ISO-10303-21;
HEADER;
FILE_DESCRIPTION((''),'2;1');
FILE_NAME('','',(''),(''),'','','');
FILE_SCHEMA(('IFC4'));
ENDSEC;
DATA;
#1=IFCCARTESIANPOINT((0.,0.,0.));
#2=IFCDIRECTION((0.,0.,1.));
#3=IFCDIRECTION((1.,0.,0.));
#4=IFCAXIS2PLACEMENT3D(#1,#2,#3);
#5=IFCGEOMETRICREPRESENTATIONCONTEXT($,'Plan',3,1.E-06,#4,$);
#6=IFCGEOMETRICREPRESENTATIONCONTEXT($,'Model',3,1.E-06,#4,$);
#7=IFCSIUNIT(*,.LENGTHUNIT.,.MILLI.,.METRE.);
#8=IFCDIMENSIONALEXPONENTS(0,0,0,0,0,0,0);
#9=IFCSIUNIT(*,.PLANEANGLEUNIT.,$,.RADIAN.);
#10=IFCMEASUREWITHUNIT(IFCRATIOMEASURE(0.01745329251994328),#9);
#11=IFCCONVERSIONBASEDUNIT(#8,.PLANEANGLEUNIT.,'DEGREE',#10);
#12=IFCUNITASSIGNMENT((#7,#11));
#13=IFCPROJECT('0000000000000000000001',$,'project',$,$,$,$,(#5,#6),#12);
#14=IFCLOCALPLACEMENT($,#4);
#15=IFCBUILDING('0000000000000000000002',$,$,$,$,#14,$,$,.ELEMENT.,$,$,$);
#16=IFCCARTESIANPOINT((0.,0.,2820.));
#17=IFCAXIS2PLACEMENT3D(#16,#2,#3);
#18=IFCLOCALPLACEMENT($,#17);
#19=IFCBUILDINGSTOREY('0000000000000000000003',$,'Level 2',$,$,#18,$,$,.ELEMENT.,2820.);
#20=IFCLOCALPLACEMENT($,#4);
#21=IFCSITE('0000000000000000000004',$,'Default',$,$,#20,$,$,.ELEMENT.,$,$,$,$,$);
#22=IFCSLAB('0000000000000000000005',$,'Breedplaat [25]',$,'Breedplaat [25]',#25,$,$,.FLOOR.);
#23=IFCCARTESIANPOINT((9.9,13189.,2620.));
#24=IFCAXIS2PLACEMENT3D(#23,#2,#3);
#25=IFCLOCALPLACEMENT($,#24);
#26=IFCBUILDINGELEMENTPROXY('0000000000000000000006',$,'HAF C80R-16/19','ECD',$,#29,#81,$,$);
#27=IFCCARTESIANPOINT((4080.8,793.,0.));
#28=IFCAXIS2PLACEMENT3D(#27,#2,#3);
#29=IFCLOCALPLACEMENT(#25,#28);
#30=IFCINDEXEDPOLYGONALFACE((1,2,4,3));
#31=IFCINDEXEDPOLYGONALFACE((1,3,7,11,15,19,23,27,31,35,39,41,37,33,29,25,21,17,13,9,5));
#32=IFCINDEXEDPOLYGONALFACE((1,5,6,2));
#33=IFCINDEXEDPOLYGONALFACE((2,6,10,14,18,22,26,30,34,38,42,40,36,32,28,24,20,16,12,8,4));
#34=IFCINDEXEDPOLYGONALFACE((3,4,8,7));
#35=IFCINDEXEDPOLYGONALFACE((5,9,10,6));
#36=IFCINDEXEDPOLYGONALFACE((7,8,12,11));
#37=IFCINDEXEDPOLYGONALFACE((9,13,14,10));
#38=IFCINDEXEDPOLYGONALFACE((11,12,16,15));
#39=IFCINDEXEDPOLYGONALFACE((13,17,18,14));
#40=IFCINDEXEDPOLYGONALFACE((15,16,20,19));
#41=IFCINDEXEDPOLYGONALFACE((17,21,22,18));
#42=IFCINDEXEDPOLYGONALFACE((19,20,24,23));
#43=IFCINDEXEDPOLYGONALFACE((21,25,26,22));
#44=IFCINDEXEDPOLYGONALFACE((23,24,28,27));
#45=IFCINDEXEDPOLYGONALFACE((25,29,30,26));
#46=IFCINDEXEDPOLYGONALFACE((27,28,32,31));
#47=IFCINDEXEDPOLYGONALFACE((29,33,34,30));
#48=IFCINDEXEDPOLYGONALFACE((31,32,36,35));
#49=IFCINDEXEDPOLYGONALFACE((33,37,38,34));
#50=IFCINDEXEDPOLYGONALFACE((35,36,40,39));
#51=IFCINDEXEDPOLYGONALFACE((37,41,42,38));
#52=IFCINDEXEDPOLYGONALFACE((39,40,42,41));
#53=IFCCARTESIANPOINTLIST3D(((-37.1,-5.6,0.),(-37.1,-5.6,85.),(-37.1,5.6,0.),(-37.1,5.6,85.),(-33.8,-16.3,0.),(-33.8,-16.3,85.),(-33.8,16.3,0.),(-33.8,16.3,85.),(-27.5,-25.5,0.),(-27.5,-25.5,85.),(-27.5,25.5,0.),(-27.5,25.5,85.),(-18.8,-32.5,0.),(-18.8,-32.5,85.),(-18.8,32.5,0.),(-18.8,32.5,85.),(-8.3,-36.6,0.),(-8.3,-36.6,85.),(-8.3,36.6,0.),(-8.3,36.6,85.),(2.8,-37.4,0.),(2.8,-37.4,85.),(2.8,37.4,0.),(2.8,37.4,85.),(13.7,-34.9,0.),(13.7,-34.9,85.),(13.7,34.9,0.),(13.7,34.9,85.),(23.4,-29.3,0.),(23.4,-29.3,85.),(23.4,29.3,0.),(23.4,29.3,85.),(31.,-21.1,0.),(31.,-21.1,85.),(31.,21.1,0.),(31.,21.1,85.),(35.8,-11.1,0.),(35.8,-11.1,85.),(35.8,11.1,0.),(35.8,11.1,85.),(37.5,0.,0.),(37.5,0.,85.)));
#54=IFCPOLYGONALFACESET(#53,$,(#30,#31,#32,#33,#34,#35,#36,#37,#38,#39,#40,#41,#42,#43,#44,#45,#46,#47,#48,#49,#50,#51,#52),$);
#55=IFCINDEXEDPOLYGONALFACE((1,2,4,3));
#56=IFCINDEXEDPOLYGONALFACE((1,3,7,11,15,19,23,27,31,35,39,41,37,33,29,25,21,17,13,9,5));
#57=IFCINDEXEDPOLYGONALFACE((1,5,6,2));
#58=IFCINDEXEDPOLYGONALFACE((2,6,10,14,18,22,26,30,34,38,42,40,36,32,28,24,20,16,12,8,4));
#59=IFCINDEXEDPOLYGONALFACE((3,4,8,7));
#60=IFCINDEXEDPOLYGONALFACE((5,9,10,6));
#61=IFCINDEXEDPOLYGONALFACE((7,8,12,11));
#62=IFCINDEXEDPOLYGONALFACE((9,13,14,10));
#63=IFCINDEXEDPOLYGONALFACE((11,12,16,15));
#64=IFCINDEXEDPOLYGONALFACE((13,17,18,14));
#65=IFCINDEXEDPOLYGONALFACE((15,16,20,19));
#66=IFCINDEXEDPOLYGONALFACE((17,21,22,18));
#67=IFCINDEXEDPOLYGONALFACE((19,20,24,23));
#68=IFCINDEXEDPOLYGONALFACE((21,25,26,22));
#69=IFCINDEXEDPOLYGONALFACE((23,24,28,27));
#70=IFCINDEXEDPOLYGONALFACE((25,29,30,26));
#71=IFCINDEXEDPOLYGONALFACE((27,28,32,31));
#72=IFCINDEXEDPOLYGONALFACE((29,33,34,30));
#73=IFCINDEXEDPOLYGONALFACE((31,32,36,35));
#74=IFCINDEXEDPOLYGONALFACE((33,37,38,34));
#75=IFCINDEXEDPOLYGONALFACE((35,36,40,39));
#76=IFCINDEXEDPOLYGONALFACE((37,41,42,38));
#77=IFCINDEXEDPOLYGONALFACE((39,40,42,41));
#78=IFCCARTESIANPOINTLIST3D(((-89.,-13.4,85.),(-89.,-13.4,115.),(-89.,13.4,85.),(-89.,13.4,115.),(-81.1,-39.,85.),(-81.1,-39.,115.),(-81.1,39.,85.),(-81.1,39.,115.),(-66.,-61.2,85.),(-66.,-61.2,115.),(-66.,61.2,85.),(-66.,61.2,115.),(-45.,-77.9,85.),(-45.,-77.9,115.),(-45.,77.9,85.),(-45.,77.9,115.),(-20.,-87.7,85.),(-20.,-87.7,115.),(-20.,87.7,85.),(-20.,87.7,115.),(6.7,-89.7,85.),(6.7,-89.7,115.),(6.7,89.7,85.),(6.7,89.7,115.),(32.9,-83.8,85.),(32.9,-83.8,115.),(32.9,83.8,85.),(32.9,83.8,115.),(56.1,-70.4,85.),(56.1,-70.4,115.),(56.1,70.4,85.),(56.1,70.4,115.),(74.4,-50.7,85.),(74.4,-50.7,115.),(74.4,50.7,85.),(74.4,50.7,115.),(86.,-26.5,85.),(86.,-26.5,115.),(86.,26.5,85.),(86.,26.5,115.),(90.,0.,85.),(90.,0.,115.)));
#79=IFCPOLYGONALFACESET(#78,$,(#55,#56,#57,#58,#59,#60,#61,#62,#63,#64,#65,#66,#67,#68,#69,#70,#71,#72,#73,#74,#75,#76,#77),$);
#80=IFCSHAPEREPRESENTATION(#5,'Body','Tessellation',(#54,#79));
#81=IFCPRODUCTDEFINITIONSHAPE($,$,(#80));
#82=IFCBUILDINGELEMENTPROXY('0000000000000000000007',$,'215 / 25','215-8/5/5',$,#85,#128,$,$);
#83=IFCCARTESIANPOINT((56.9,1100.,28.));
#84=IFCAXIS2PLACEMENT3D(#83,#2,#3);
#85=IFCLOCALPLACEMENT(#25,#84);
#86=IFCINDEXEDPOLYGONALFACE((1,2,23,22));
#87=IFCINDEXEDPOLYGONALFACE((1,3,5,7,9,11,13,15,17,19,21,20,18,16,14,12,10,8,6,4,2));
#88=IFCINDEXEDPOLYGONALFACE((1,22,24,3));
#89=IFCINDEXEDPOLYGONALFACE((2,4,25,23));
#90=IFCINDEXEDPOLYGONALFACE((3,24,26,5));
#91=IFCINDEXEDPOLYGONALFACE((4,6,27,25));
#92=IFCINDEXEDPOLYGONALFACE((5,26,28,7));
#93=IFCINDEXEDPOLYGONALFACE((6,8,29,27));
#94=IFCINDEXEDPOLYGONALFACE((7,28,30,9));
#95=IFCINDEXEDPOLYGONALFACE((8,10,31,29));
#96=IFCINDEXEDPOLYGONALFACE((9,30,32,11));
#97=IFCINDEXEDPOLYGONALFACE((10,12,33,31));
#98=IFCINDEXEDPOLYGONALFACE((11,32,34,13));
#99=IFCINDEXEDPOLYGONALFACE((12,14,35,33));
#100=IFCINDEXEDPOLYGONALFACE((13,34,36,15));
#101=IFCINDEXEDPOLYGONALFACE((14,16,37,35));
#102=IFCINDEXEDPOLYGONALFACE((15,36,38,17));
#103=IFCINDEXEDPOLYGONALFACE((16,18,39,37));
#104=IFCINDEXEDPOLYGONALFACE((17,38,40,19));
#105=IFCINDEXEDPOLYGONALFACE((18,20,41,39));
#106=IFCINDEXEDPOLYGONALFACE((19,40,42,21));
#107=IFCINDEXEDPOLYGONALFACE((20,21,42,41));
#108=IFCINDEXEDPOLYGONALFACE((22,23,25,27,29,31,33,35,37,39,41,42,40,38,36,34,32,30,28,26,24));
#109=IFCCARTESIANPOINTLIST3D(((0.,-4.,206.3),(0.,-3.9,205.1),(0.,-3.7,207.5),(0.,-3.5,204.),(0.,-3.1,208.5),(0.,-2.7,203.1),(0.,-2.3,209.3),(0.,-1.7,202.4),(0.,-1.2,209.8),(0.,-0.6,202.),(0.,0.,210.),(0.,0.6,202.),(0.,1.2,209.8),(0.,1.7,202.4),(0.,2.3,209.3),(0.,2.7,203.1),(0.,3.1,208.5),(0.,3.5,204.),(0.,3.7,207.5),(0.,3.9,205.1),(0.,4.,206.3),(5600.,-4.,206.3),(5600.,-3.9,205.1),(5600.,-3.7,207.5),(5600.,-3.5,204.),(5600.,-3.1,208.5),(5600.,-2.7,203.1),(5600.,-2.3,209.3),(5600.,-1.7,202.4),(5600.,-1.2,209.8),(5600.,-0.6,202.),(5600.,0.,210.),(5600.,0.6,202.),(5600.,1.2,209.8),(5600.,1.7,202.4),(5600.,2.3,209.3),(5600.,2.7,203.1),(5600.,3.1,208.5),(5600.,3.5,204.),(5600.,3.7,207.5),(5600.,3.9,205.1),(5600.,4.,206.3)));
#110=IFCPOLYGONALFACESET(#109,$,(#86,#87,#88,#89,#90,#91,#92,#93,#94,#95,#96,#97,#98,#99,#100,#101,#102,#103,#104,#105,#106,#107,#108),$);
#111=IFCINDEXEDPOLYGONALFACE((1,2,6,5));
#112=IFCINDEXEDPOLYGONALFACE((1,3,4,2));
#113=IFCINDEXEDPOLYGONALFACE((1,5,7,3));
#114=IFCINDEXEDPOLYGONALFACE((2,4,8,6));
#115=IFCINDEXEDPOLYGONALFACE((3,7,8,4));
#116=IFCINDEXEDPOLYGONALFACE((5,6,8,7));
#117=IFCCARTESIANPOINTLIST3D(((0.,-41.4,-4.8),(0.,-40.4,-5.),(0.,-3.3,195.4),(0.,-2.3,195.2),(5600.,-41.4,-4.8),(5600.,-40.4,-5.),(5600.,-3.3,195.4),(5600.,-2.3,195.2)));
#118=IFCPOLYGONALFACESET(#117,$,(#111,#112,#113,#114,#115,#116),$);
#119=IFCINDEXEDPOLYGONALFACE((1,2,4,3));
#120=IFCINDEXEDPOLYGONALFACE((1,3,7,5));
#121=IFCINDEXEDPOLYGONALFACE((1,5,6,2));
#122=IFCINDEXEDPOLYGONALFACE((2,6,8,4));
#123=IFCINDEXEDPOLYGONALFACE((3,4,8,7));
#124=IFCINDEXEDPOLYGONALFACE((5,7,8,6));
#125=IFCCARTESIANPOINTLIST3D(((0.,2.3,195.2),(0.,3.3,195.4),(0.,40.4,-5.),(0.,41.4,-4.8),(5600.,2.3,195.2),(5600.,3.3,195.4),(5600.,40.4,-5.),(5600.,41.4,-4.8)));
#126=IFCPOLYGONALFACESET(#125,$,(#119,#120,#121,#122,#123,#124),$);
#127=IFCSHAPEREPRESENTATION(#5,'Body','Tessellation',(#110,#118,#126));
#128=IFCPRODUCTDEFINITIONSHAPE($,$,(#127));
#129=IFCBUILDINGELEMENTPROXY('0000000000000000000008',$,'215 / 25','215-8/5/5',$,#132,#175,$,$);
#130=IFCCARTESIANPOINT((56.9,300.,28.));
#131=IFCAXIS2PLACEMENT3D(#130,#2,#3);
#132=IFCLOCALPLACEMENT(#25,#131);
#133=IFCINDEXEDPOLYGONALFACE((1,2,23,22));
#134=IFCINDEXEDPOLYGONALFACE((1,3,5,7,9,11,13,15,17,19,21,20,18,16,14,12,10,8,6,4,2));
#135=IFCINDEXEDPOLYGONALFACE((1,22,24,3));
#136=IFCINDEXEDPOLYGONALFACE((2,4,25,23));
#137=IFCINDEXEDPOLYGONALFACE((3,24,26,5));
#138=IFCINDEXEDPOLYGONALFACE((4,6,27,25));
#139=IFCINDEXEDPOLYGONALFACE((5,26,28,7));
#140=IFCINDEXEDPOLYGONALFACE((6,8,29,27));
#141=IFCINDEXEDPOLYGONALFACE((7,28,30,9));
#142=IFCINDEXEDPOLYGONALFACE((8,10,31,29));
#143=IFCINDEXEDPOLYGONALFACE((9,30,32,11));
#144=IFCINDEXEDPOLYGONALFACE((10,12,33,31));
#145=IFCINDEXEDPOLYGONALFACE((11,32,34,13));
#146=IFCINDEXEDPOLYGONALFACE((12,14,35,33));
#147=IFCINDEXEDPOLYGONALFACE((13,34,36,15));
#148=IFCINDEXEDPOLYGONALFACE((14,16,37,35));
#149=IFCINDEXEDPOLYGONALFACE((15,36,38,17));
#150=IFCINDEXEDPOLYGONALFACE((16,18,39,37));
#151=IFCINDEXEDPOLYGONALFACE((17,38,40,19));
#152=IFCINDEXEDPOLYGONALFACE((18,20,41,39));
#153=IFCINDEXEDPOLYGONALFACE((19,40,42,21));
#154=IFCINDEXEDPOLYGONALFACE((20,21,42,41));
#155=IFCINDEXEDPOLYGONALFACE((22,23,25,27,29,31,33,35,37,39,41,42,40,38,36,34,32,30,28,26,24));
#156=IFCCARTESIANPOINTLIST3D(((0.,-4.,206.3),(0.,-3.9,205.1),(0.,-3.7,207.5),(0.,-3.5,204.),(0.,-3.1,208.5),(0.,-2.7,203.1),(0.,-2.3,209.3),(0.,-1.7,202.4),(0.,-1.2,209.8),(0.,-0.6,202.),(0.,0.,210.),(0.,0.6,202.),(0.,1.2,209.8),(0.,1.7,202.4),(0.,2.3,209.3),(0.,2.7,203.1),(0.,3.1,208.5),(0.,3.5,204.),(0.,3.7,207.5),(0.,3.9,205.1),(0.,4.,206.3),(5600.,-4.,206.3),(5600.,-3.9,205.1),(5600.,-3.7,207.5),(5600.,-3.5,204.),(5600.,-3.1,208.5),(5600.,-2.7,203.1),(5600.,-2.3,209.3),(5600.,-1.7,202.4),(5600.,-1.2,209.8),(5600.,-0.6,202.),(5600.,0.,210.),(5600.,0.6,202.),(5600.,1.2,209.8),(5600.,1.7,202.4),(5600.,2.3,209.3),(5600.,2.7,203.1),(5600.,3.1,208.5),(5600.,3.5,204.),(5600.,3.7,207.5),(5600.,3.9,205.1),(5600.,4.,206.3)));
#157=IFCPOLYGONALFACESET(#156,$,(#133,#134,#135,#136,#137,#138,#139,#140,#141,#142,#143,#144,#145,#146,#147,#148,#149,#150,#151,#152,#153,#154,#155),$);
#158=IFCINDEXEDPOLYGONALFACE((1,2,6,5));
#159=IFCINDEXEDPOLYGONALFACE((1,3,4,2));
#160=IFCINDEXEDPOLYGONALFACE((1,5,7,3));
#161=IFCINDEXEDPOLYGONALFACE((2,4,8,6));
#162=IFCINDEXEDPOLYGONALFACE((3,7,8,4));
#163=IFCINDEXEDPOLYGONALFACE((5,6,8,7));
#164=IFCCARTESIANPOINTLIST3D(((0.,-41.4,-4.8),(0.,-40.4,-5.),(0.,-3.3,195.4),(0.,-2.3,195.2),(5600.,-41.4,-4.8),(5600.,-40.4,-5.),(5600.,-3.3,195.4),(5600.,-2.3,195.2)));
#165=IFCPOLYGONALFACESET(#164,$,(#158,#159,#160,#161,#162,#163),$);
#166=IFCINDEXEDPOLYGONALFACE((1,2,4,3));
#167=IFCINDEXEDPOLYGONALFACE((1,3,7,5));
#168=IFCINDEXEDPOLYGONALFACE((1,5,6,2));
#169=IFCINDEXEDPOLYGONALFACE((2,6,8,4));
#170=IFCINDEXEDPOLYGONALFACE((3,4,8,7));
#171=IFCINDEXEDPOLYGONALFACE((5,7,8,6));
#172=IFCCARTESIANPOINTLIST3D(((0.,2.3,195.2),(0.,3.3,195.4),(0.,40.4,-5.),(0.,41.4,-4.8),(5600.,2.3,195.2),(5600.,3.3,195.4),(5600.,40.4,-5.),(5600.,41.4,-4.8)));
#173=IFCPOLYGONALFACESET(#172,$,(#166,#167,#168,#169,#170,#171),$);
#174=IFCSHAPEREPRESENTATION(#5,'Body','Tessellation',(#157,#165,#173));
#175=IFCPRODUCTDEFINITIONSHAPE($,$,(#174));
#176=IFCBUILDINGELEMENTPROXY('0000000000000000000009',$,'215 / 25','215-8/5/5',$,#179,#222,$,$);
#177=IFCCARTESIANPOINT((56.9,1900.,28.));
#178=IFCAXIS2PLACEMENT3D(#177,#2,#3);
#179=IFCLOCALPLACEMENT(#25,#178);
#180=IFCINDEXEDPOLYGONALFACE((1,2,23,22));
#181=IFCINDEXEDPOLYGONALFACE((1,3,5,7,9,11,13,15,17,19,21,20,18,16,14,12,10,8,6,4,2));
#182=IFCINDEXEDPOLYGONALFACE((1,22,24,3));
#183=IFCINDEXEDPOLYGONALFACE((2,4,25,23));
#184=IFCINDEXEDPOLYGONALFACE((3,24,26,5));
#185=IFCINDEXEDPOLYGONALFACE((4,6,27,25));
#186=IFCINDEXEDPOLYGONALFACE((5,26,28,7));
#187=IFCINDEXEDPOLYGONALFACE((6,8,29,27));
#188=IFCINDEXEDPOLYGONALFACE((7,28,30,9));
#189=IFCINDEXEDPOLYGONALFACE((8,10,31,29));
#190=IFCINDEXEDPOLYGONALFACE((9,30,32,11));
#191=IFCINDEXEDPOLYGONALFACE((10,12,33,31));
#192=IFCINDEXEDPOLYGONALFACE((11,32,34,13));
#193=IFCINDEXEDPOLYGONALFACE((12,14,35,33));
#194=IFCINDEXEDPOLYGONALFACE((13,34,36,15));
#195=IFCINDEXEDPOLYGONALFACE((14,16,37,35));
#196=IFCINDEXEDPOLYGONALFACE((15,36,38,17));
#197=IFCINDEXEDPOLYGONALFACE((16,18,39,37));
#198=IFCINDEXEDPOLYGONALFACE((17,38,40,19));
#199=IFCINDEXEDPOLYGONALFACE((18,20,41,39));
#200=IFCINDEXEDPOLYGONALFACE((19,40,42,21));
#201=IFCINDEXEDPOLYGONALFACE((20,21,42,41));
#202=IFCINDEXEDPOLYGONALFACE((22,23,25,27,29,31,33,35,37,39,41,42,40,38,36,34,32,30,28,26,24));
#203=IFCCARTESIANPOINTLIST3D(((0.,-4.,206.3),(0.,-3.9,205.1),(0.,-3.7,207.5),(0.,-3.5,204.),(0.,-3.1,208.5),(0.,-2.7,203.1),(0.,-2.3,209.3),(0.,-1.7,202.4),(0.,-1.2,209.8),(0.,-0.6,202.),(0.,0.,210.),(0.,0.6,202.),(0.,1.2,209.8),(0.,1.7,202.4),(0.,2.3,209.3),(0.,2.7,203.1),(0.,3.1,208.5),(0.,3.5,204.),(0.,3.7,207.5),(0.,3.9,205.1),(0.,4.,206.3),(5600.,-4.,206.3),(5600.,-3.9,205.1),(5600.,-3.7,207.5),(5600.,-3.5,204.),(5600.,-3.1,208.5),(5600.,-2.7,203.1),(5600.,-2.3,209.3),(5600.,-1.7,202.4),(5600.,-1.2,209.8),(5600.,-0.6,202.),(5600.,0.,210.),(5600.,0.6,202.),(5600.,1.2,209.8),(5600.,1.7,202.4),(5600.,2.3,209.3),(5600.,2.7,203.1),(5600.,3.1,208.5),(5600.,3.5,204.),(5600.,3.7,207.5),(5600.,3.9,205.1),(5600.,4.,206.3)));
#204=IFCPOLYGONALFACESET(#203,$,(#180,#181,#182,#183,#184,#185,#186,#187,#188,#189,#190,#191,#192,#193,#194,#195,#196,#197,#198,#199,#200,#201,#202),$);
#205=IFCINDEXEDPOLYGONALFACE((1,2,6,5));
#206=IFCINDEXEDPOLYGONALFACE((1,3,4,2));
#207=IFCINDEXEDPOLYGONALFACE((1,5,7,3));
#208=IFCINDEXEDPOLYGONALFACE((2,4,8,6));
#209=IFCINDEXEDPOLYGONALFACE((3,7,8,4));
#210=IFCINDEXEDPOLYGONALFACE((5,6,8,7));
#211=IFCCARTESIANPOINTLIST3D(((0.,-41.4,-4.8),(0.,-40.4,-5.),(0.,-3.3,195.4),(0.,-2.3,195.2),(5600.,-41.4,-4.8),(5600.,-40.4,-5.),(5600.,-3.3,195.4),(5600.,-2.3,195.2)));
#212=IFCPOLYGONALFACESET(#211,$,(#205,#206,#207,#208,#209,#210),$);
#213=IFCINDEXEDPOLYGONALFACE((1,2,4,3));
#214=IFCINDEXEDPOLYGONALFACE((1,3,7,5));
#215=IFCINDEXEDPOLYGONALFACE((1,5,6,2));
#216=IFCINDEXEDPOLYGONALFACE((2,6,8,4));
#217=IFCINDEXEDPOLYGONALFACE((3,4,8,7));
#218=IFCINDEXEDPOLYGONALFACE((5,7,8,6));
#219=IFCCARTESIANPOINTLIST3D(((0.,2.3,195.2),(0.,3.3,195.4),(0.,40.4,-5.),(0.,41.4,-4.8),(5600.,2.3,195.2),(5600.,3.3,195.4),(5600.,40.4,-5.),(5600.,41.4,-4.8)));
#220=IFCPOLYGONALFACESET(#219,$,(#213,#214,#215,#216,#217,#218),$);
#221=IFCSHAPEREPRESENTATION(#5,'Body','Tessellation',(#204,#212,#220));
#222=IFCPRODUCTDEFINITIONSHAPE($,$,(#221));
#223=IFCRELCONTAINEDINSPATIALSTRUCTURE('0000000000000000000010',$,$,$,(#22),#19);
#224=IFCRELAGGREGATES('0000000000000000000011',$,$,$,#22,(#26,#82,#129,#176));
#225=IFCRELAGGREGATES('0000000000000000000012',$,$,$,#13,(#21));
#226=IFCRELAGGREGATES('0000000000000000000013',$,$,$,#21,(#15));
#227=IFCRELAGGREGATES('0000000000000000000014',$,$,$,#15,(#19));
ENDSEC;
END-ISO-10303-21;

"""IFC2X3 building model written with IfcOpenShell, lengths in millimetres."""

from ifc_helpers import new_model, entity, si_unit, converted_unit, frame, origin_with_axes, origin_2d_with_axis, place, context, project, spatial, rectangle, circle, extrude, element, aggregate, save


model = new_model("IFC2X3")

# Units and contexts
plan_context = context("Plan", 3, precision=1e-06, world=origin_with_axes())
model_context = context("Model", 3, precision=1e-06, world=origin_with_axes())
ifc_project = project(units=[si_unit("LENGTHUNIT", "METRE", prefix="MILLI"), converted_unit("PLANEANGLEUNIT", "DEGREE", entity("IfcRatioMeasure", 0.01745329251994328), si_unit("PLANEANGLEUNIT", "RADIAN"), dimensions=[0, 0, 0, 0, 0, 0, 0])], contexts=[plan_context, model_context])

# Site, building, storey
site_placement = place(None, origin_with_axes())
site = spatial("IfcSite", under=ifc_project, at=site_placement, Name="Default", CompositionType="ELEMENT")
building_placement = place(None, origin_with_axes())
building = spatial("IfcBuilding", under=site, at=building_placement, CompositionType="ELEMENT")
storey_placement = place(None, frame((0.0, 0.0, 2820.0), z_axis=(0.0, 0.0, 1.0), x_axis=(1.0, 0.0, 0.0)))
storey = spatial("IfcBuildingStorey", under=building, at=storey_placement, Name="Level 2", CompositionType="ELEMENT", Elevation=2820.0)

# Slab, building element proxies
slab_1_placement = place(None, frame((9.9, 13189.0, 2620.0), z_axis=(0.0, 0.0, 1.0), x_axis=(1.0, 0.0, 0.0)))
slab_1 = element("IfcSlab", 1, at=slab_1_placement, inside=storey, Name="Breedplaat [25]", ObjectType="Breedplaat [25]", PredefinedType="FLOOR")
proxy_1_placement = place(slab_1_placement, frame((4080.8, 793.0, 0.0), z_axis=(0.0, 0.0, 1.0), x_axis=(1.0, 0.0, 0.0)))
proxy_1 = element("IfcBuildingElementProxy", 2, at=proxy_1_placement, Name="HAF C80R-16/19", Description="ECD", context=plan_context, shape_type="SweptSolid", body=[
    extrude(circle(Radius=37.5, at=origin_2d_with_axis()), origin_with_axes(), (0.0, 0.0, 1.0), 85.0),
    extrude(circle(Radius=90.0, at=origin_2d_with_axis()), frame((0.0, 0.0, 85.0), z_axis=(0.0, 0.0, 1.0), x_axis=(1.0, 0.0, 0.0)), (0.0, 0.0, 1.0), 30.0),
])
proxy_2_placement = place(slab_1_placement, frame((56.9, 1100.0, 28.0), z_axis=(0.0, 0.0, 1.0), x_axis=(1.0, 0.0, 0.0)))
proxy_2 = element("IfcBuildingElementProxy", 3, at=proxy_2_placement, Name="215 / 25", Description="215-8/5/5", context=plan_context, shape_type="SweptSolid", body=[
    extrude(circle(Radius=4.0, at=origin_2d_with_axis()), frame((0.0, 0.0, 206.0), z_axis=(1.0, 0.0, 0.0), x_axis=(0.0, 0.0, 1.0)), (0.0, 0.0, 1.0), 5600.0),
    extrude(rectangle(XDim=203.8, YDim=1.0, at=origin_2d_with_axis()), frame((0.0, -21.9, 95.2), z_axis=(1.0, 0.0, 0.0), x_axis=(0.0, 0.187112, 0.982339)), (0.0, 0.0, 1.0), 5600.0),
    extrude(rectangle(XDim=203.8, YDim=1.0, at=origin_2d_with_axis()), frame((0.0, 21.9, 95.2), z_axis=(1.0, 0.0, 0.0), x_axis=(0.0, -0.187112, 0.982339)), (0.0, 0.0, 1.0), 5600.0),
])
proxy_3_placement = place(slab_1_placement, frame((56.9, 300.0, 28.0), z_axis=(0.0, 0.0, 1.0), x_axis=(1.0, 0.0, 0.0)))
proxy_3 = element("IfcBuildingElementProxy", 4, at=proxy_3_placement, Name="215 / 25", Description="215-8/5/5", context=plan_context, shape_type="SweptSolid", body=[
    extrude(circle(Radius=4.0, at=origin_2d_with_axis()), frame((0.0, 0.0, 206.0), z_axis=(1.0, 0.0, 0.0), x_axis=(0.0, 0.0, 1.0)), (0.0, 0.0, 1.0), 5600.0),
    extrude(rectangle(XDim=203.8, YDim=1.0, at=origin_2d_with_axis()), frame((0.0, -21.9, 95.2), z_axis=(1.0, 0.0, 0.0), x_axis=(0.0, 0.187112, 0.982339)), (0.0, 0.0, 1.0), 5600.0),
    extrude(rectangle(XDim=203.8, YDim=1.0, at=origin_2d_with_axis()), frame((0.0, 21.9, 95.2), z_axis=(1.0, 0.0, 0.0), x_axis=(0.0, -0.187112, 0.982339)), (0.0, 0.0, 1.0), 5600.0),
])
proxy_4_placement = place(slab_1_placement, frame((56.9, 1900.0, 28.0), z_axis=(0.0, 0.0, 1.0), x_axis=(1.0, 0.0, 0.0)))
proxy_4 = element("IfcBuildingElementProxy", 5, at=proxy_4_placement, Name="215 / 25", Description="215-8/5/5", context=plan_context, shape_type="SweptSolid", body=[
    extrude(circle(Radius=4.0, at=origin_2d_with_axis()), frame((0.0, 0.0, 206.0), z_axis=(1.0, 0.0, 0.0), x_axis=(0.0, 0.0, 1.0)), (0.0, 0.0, 1.0), 5600.0),
    extrude(rectangle(XDim=203.8, YDim=1.0, at=origin_2d_with_axis()), frame((0.0, -21.9, 95.2), z_axis=(1.0, 0.0, 0.0), x_axis=(0.0, 0.187112, 0.982339)), (0.0, 0.0, 1.0), 5600.0),
    extrude(rectangle(XDim=203.8, YDim=1.0, at=origin_2d_with_axis()), frame((0.0, 21.9, 95.2), z_axis=(1.0, 0.0, 0.0), x_axis=(0.0, -0.187112, 0.982339)), (0.0, 0.0, 1.0), 5600.0),
])
aggregate(slab_1, [proxy_1, proxy_2, proxy_3, proxy_4])

save(model, "model.ifc")
